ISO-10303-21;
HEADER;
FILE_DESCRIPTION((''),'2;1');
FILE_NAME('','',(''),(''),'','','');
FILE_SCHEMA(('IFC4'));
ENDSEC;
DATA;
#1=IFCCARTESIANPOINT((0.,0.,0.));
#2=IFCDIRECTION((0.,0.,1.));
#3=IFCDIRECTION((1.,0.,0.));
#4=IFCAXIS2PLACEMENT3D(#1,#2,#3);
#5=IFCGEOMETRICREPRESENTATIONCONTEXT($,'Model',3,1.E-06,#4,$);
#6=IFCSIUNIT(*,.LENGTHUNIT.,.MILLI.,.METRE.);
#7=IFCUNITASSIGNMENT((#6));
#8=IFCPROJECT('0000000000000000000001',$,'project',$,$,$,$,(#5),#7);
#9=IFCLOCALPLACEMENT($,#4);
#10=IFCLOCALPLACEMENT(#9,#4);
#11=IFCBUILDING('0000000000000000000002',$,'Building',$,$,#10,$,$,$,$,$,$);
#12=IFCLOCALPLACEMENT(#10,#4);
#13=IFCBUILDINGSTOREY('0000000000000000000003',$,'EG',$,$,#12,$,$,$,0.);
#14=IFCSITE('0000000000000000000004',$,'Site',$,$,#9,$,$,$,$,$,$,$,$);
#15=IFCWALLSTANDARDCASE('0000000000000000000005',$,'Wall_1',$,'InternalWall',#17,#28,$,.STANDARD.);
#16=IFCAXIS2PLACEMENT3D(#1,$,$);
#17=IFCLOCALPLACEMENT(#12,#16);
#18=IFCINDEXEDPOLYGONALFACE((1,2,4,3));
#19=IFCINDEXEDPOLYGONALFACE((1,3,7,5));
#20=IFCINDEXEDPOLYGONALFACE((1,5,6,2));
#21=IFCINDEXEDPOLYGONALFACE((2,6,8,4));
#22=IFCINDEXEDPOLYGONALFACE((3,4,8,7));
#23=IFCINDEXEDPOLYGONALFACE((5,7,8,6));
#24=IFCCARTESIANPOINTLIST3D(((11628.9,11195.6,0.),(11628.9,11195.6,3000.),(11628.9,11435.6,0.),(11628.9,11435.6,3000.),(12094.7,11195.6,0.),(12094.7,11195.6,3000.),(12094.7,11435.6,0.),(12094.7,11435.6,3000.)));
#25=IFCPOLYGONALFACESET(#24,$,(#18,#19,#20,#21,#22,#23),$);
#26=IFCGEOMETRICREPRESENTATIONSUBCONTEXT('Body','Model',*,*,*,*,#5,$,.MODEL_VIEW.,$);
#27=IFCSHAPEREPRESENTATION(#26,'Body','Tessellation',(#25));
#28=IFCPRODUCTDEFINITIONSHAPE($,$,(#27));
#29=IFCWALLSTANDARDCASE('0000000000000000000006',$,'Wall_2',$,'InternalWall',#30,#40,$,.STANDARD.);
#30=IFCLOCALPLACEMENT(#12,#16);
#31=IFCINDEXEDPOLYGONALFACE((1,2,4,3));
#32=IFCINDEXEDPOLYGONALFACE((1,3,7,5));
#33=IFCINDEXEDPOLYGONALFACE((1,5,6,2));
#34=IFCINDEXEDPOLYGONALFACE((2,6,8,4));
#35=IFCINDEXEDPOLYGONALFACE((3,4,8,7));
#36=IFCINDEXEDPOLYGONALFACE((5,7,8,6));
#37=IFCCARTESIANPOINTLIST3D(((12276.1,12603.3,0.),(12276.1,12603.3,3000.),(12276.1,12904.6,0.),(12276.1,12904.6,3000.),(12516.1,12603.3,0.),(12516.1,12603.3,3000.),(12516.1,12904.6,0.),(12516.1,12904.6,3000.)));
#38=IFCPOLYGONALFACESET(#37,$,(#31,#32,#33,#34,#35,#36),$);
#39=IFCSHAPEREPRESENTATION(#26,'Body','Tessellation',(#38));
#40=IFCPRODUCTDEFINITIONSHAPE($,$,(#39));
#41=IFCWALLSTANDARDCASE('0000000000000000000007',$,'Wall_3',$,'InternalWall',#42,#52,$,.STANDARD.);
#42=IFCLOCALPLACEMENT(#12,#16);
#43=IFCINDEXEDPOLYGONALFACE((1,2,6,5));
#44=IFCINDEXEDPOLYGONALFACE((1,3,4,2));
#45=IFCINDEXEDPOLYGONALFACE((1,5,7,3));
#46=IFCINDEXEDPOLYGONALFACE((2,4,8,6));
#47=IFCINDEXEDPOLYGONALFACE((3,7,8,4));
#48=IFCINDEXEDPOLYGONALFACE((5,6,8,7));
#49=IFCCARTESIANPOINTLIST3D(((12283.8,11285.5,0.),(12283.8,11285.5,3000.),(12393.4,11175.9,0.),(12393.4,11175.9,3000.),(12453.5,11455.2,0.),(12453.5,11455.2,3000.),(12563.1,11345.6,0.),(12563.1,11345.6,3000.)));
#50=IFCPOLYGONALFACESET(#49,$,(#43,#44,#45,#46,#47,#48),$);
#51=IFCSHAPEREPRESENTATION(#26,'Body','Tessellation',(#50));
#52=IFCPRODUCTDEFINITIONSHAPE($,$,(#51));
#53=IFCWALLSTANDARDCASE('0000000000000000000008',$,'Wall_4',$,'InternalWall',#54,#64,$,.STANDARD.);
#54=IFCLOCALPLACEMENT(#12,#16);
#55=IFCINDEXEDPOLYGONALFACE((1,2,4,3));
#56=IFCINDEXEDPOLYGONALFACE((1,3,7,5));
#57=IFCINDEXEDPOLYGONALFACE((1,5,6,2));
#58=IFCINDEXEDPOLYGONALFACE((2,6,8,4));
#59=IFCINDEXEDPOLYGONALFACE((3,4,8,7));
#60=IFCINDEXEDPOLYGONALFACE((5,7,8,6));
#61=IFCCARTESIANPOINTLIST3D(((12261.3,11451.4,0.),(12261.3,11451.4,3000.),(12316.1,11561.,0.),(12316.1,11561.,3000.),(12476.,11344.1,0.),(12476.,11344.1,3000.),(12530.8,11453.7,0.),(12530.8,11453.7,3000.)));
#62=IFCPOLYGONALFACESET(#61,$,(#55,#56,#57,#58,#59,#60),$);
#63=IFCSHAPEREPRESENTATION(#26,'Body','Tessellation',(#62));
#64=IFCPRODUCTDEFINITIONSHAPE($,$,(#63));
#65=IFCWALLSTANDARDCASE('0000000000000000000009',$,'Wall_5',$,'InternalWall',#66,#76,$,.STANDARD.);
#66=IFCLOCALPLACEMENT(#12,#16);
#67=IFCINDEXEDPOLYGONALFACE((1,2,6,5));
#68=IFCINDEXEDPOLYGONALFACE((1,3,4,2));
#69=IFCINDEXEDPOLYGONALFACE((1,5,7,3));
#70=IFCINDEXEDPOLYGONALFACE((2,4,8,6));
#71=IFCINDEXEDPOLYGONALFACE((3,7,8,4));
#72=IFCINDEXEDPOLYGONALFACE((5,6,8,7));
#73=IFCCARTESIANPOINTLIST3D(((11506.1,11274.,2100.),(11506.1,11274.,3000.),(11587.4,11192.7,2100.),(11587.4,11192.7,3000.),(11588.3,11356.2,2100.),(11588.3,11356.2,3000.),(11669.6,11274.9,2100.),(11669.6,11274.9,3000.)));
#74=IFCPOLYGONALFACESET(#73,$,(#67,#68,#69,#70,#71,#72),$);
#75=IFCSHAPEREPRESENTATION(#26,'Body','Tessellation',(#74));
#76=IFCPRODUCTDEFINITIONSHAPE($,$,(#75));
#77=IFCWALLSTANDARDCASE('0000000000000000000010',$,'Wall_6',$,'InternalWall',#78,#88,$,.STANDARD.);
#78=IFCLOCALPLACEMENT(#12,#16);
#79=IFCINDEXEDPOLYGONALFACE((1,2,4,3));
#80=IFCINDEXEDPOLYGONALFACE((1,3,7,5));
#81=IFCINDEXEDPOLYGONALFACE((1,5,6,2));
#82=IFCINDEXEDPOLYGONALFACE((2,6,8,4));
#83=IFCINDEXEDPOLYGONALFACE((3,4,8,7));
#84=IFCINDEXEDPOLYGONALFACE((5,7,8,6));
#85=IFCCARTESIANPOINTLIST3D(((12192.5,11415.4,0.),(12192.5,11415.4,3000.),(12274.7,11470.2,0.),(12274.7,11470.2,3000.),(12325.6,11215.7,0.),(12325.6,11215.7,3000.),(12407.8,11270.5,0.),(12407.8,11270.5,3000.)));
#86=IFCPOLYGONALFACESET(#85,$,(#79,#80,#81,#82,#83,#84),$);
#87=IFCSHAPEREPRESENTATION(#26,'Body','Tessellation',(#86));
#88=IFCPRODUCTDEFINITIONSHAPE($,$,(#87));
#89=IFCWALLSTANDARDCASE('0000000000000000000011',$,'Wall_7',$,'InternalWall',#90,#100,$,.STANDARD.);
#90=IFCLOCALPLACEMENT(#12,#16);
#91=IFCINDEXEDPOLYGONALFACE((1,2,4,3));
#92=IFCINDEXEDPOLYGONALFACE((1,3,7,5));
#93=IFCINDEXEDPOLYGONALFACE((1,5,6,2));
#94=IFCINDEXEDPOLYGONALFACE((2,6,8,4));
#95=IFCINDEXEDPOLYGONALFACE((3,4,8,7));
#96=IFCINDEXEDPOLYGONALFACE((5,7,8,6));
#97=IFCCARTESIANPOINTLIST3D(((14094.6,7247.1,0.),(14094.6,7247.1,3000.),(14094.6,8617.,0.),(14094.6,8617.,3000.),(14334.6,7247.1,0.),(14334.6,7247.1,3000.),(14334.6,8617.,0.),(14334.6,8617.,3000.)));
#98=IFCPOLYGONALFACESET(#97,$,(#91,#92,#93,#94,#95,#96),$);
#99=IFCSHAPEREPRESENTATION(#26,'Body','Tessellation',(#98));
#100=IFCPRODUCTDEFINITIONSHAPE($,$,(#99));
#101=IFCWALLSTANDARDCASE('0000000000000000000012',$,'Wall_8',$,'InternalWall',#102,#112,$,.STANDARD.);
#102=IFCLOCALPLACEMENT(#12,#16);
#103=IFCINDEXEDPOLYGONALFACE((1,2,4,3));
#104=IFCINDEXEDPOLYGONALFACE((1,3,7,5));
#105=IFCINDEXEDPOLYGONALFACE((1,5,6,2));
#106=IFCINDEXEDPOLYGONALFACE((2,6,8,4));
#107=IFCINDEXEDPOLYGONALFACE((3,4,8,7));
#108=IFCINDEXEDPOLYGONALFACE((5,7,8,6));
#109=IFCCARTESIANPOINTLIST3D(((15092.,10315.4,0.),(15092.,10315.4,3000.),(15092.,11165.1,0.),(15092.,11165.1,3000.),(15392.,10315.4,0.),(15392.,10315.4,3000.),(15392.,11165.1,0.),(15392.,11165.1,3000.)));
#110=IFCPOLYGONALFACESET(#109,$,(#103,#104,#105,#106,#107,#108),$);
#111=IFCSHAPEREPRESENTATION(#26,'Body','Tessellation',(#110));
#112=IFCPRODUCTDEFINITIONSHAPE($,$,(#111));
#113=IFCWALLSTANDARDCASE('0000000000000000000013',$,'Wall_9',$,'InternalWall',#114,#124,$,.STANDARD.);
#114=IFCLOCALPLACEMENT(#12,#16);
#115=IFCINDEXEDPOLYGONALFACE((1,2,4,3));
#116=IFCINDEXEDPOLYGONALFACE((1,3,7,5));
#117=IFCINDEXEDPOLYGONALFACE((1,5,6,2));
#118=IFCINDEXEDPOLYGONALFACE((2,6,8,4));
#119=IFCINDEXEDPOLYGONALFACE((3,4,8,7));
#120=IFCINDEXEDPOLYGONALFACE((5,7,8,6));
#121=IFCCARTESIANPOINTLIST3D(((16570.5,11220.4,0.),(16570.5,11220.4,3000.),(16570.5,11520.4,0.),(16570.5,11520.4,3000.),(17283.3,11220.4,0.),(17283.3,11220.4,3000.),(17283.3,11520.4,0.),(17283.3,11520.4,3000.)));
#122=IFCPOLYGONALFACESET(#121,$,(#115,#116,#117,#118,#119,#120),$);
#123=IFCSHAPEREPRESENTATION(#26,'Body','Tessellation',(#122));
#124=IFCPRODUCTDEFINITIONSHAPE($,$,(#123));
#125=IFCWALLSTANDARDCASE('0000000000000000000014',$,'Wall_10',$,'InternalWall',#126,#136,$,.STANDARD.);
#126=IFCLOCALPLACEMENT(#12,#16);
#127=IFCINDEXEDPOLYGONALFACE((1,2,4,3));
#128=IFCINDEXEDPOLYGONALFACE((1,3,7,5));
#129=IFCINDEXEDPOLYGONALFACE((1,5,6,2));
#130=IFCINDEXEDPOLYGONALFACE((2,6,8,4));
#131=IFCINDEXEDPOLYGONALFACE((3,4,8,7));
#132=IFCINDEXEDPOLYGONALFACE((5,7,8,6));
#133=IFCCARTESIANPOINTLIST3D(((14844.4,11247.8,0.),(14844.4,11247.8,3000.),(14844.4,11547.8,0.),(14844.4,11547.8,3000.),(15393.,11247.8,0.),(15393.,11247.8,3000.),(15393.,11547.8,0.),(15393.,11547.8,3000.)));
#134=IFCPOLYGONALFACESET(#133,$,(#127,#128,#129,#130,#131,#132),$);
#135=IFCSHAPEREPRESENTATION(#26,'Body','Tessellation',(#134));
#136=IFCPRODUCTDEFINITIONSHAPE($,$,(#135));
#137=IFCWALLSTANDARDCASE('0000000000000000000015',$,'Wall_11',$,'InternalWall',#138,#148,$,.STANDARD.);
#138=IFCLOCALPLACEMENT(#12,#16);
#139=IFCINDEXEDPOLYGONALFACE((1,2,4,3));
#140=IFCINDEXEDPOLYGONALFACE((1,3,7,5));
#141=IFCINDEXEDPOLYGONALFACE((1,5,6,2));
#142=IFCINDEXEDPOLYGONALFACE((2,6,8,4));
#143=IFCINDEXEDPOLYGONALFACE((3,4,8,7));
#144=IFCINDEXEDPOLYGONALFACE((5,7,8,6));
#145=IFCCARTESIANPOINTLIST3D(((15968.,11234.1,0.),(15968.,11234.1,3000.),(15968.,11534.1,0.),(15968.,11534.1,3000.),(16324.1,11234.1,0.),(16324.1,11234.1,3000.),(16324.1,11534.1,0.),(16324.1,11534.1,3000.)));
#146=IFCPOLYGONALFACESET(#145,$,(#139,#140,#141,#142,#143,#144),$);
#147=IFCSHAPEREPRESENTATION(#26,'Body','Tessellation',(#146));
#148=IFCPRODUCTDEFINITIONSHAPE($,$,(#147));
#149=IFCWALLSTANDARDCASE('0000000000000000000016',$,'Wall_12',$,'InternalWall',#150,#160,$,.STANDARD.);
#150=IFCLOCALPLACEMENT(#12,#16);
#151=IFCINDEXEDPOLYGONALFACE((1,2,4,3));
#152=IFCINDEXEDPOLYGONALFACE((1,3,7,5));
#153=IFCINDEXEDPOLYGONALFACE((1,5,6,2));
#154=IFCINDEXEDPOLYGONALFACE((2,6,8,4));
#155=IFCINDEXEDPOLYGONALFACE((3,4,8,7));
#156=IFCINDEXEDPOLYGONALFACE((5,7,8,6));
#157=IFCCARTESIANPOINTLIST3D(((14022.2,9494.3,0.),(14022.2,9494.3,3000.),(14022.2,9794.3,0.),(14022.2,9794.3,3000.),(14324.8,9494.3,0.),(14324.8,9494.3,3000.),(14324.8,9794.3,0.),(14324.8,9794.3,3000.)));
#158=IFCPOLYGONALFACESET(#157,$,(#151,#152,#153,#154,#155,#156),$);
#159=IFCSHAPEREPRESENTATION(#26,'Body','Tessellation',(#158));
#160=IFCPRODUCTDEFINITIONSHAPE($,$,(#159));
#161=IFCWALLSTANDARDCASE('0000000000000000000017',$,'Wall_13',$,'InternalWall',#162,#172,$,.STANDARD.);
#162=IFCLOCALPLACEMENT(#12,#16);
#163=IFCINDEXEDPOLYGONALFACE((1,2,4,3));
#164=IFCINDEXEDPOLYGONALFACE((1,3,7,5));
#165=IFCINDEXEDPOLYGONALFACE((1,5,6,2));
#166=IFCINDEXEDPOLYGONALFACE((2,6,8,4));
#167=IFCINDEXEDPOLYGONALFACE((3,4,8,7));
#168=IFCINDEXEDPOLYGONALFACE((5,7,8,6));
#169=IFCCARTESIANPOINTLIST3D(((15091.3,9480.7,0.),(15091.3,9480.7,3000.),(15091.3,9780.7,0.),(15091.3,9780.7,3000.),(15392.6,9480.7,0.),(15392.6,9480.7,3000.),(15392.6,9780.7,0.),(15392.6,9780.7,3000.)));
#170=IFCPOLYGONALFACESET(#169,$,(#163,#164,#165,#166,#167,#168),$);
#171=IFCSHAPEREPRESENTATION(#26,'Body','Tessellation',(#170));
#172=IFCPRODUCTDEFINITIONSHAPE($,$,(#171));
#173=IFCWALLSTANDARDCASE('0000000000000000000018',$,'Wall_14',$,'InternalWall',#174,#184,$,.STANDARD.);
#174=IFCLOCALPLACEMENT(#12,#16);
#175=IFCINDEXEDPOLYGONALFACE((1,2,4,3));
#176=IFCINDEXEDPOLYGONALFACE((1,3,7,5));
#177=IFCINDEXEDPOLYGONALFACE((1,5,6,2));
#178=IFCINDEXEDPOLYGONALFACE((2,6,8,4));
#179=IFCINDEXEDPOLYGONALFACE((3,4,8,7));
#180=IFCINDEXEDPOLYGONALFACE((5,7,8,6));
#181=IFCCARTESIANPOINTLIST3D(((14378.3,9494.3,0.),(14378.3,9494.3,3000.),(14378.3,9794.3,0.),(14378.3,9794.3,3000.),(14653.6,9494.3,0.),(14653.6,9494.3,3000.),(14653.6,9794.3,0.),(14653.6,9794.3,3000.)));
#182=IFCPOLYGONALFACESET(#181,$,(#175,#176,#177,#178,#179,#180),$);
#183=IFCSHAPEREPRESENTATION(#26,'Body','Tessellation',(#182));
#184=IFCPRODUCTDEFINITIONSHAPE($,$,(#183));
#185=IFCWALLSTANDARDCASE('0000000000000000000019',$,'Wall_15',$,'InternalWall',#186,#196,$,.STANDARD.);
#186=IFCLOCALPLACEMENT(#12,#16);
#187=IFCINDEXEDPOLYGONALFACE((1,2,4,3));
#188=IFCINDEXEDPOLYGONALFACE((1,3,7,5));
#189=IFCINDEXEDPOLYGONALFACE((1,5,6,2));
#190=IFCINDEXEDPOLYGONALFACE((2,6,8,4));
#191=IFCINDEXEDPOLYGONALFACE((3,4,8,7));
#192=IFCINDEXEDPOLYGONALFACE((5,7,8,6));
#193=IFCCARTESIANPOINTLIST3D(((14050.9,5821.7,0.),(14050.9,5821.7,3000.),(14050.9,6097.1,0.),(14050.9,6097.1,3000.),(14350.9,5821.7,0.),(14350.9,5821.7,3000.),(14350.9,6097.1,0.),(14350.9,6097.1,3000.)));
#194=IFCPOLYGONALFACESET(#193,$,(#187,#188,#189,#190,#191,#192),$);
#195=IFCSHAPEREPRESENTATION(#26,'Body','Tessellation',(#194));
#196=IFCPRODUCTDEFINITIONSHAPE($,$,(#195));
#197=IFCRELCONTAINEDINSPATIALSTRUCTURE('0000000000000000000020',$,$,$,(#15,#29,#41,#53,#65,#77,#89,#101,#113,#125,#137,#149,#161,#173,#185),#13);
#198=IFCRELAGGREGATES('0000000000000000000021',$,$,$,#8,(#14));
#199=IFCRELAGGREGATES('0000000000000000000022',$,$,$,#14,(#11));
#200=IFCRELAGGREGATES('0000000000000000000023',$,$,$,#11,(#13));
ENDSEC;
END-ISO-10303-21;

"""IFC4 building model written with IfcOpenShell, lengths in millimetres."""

from ifc_helpers import new_model, si_unit, frame, origin_with_axes, place, context, subcontext, project, spatial, rectangle, extrude, element, save


model = new_model("IFC4")

# Units and contexts
model_context = context("Model", 3, precision=1e-06, world=origin_with_axes())
body_context = subcontext(model_context, "Body", "Model", "MODEL_VIEW")
ifc_project = project(units=[si_unit("LENGTHUNIT", "METRE", prefix="MILLI")], contexts=[model_context])

# Site, building, storey
site_placement = place(None, origin_with_axes())
site = spatial("IfcSite", under=ifc_project, at=site_placement, Name="Site")
building_placement = place(site_placement, origin_with_axes())
building = spatial("IfcBuilding", under=site, at=building_placement, Name="Building")
storey_placement = place(building_placement, origin_with_axes())
storey = spatial("IfcBuildingStorey", under=building, at=storey_placement, Name="EG", Elevation=0.0)

# Walls
wall_1_placement = place(storey_placement, origin_with_axes())
element("IfcWallStandardCase", 1, at=wall_1_placement, inside=storey, Name="Wall_1", ObjectType="InternalWall", PredefinedType="STANDARD", context=body_context, shape_type="SweptSolid", body=[
    extrude(rectangle(XDim=465.8, YDim=240.0), frame((11861.8, 11315.6, 0.0), z_axis=(0.0, 0.0, 1.0), x_axis=(-1.0, 0.0, 0.0)), (0.0, 0.0, 1.0), 3000.0),
])
wall_2_placement = place(storey_placement, origin_with_axes())
element("IfcWallStandardCase", 2, at=wall_2_placement, inside=storey, Name="Wall_2", ObjectType="InternalWall", PredefinedType="STANDARD", context=body_context, shape_type="SweptSolid", body=[
    extrude(rectangle(XDim=301.4, YDim=240.0), frame((12396.1, 12753.9, 0.0), z_axis=(0.0, 0.0, 1.0), x_axis=(0.0, -1.0, 0.0)), (0.0, 0.0, 1.0), 3000.0),
])
wall_3_placement = place(storey_placement, origin_with_axes())
element("IfcWallStandardCase", 3, at=wall_3_placement, inside=storey, Name="Wall_3", ObjectType="InternalWall", PredefinedType="STANDARD", context=body_context, shape_type="SweptSolid", body=[
    extrude(rectangle(XDim=155.0, YDim=240.0), frame((12423.5, 11315.6, 0.0), z_axis=(0.0, 0.0, 1.0), x_axis=(0.707107, -0.707107, 0.0)), (0.0, 0.0, 1.0), 3000.0),
])
wall_4_placement = place(storey_placement, origin_with_axes())
element("IfcWallStandardCase", 4, at=wall_4_placement, inside=storey, Name="Wall_4", ObjectType="InternalWall", PredefinedType="STANDARD", context=body_context, shape_type="SweptSolid", body=[
    extrude(rectangle(XDim=122.5, YDim=240.0), frame((12396.1, 11452.6, 0.0), z_axis=(0.0, 0.0, 1.0), x_axis=(-0.447214, -0.894427, 0.0)), (0.0, 0.0, 1.0), 3000.0),
])

# Wall, opening
wall_5_placement = place(storey_placement, origin_with_axes())
wall_5 = element("IfcWallStandardCase", 5, at=wall_5_placement, inside=storey, Name="Wall_5", ObjectType="InternalWall", PredefinedType="STANDARD", context=body_context, shape_type="SweptSolid", body=[
    extrude(rectangle(XDim=116.2, YDim=115.0), frame((11587.8, 11274.5, 0.0), z_axis=(0.0, 0.0, 1.0), x_axis=(-0.707107, -0.707107, 0.0)), (0.0, 0.0, 1.0), 3000.0),
])
opening_1_placement = place(wall_5_placement, origin_with_axes())
element("IfcOpeningElement", 6, at=opening_1_placement, inside=storey, cuts=wall_5, context=body_context, shape_type="SweptSolid", body=[
    extrude(rectangle(XDim=941.7, YDim=115.0), frame((11431.0, 11117.6, 0.0), z_axis=(0.0, 0.0, 1.0), x_axis=(-0.707107, -0.707107, 0.0)), (0.0, 0.0, 1.0), 2100.0),
])

# Walls
wall_6_placement = place(storey_placement, origin_with_axes())
element("IfcWallStandardCase", 7, at=wall_6_placement, inside=storey, Name="Wall_6", ObjectType="InternalWall", PredefinedType="STANDARD", context=body_context, shape_type="SweptSolid", body=[
    extrude(rectangle(XDim=98.8, YDim=240.0), frame((12300.2, 11343.0, 0.0), z_axis=(0.0, 0.0, 1.0), x_axis=(-0.83205, -0.5547, 0.0)), (0.0, 0.0, 1.0), 3000.0),
])
wall_7_placement = place(storey_placement, origin_with_axes())
element("IfcWallStandardCase", 8, at=wall_7_placement, inside=storey, Name="Wall_7", ObjectType="InternalWall", PredefinedType="STANDARD", context=body_context, shape_type="SweptSolid", body=[
    extrude(rectangle(XDim=1369.9, YDim=240.0), frame((14214.6, 7932.0, 0.0), z_axis=(0.0, 0.0, 1.0), x_axis=(0.0, -1.0, 0.0)), (0.0, 0.0, 1.0), 3000.0),
])
wall_8_placement = place(storey_placement, origin_with_axes())
element("IfcWallStandardCase", 9, at=wall_8_placement, inside=storey, Name="Wall_8", ObjectType="InternalWall", PredefinedType="STANDARD", context=body_context, shape_type="SweptSolid", body=[
    extrude(rectangle(XDim=849.8, YDim=300.0), frame((15242.0, 10740.2, 0.0), z_axis=(0.0, 0.0, 1.0), x_axis=(0.0, 1.0, 0.0)), (0.0, 0.0, 1.0), 3000.0),
])
wall_9_placement = place(storey_placement, origin_with_axes())
element("IfcWallStandardCase", 10, at=wall_9_placement, inside=storey, Name="Wall_9", ObjectType="InternalWall", PredefinedType="STANDARD", context=body_context, shape_type="SweptSolid", body=[
    extrude(rectangle(XDim=712.9, YDim=300.0), frame((16926.9, 11370.4, 0.0), z_axis=(0.0, 0.0, 1.0), x_axis=(1.0, 0.0, 0.0)), (0.0, 0.0, 1.0), 3000.0),
])
wall_10_placement = place(storey_placement, origin_with_axes())
element("IfcWallStandardCase", 11, at=wall_10_placement, inside=storey, Name="Wall_10", ObjectType="InternalWall", PredefinedType="STANDARD", context=body_context, shape_type="SweptSolid", body=[
    extrude(rectangle(XDim=548.6, YDim=300.0), frame((15118.7, 11397.8, 0.0), z_axis=(0.0, 0.0, 1.0), x_axis=(1.0, 0.0, 0.0)), (0.0, 0.0, 1.0), 3000.0),
])
wall_11_placement = place(storey_placement, origin_with_axes())
element("IfcWallStandardCase", 12, at=wall_11_placement, inside=storey, Name="Wall_11", ObjectType="InternalWall", PredefinedType="STANDARD", context=body_context, shape_type="SweptSolid", body=[
    extrude(rectangle(XDim=356.2, YDim=300.0), frame((16146.1, 11384.1, 0.0), z_axis=(0.0, 0.0, 1.0), x_axis=(-1.0, 0.0, 0.0)), (0.0, 0.0, 1.0), 3000.0),
])
wall_12_placement = place(storey_placement, origin_with_axes())
element("IfcWallStandardCase", 13, at=wall_12_placement, inside=storey, Name="Wall_12", ObjectType="InternalWall", PredefinedType="STANDARD", context=body_context, shape_type="SweptSolid", body=[
    extrude(rectangle(XDim=302.6, YDim=300.0), frame((14173.5, 9644.3, 0.0), z_axis=(0.0, 0.0, 1.0), x_axis=(1.0, 0.0, 0.0)), (0.0, 0.0, 1.0), 3000.0),
])
wall_13_placement = place(storey_placement, origin_with_axes())
element("IfcWallStandardCase", 14, at=wall_13_placement, inside=storey, Name="Wall_13", ObjectType="InternalWall", PredefinedType="STANDARD", context=body_context, shape_type="SweptSolid", body=[
    extrude(rectangle(XDim=301.4, YDim=300.0), frame((15242.0, 9630.7, 0.0), z_axis=(0.0, 0.0, 1.0), x_axis=(1.0, 0.0, 0.0)), (0.0, 0.0, 1.0), 3000.0),
])
wall_14_placement = place(storey_placement, origin_with_axes())
element("IfcWallStandardCase", 15, at=wall_14_placement, inside=storey, Name="Wall_14", ObjectType="InternalWall", PredefinedType="STANDARD", context=body_context, shape_type="SweptSolid", body=[
    extrude(rectangle(XDim=275.3, YDim=300.0), frame((14515.9, 9644.3, 0.0), z_axis=(0.0, 0.0, 1.0), x_axis=(1.0, 0.0, 0.0)), (0.0, 0.0, 1.0), 3000.0),
])
wall_15_placement = place(storey_placement, origin_with_axes())
element("IfcWallStandardCase", 16, at=wall_15_placement, inside=storey, Name="Wall_15", ObjectType="InternalWall", PredefinedType="STANDARD", context=body_context, shape_type="SweptSolid", body=[
    extrude(rectangle(XDim=275.3, YDim=300.0), frame((14200.9, 5959.4, 0.0), z_axis=(0.0, 0.0, 1.0), x_axis=(0.0, -1.0, 0.0)), (0.0, 0.0, 1.0), 3000.0),
])

save(model, "model.ifc")
